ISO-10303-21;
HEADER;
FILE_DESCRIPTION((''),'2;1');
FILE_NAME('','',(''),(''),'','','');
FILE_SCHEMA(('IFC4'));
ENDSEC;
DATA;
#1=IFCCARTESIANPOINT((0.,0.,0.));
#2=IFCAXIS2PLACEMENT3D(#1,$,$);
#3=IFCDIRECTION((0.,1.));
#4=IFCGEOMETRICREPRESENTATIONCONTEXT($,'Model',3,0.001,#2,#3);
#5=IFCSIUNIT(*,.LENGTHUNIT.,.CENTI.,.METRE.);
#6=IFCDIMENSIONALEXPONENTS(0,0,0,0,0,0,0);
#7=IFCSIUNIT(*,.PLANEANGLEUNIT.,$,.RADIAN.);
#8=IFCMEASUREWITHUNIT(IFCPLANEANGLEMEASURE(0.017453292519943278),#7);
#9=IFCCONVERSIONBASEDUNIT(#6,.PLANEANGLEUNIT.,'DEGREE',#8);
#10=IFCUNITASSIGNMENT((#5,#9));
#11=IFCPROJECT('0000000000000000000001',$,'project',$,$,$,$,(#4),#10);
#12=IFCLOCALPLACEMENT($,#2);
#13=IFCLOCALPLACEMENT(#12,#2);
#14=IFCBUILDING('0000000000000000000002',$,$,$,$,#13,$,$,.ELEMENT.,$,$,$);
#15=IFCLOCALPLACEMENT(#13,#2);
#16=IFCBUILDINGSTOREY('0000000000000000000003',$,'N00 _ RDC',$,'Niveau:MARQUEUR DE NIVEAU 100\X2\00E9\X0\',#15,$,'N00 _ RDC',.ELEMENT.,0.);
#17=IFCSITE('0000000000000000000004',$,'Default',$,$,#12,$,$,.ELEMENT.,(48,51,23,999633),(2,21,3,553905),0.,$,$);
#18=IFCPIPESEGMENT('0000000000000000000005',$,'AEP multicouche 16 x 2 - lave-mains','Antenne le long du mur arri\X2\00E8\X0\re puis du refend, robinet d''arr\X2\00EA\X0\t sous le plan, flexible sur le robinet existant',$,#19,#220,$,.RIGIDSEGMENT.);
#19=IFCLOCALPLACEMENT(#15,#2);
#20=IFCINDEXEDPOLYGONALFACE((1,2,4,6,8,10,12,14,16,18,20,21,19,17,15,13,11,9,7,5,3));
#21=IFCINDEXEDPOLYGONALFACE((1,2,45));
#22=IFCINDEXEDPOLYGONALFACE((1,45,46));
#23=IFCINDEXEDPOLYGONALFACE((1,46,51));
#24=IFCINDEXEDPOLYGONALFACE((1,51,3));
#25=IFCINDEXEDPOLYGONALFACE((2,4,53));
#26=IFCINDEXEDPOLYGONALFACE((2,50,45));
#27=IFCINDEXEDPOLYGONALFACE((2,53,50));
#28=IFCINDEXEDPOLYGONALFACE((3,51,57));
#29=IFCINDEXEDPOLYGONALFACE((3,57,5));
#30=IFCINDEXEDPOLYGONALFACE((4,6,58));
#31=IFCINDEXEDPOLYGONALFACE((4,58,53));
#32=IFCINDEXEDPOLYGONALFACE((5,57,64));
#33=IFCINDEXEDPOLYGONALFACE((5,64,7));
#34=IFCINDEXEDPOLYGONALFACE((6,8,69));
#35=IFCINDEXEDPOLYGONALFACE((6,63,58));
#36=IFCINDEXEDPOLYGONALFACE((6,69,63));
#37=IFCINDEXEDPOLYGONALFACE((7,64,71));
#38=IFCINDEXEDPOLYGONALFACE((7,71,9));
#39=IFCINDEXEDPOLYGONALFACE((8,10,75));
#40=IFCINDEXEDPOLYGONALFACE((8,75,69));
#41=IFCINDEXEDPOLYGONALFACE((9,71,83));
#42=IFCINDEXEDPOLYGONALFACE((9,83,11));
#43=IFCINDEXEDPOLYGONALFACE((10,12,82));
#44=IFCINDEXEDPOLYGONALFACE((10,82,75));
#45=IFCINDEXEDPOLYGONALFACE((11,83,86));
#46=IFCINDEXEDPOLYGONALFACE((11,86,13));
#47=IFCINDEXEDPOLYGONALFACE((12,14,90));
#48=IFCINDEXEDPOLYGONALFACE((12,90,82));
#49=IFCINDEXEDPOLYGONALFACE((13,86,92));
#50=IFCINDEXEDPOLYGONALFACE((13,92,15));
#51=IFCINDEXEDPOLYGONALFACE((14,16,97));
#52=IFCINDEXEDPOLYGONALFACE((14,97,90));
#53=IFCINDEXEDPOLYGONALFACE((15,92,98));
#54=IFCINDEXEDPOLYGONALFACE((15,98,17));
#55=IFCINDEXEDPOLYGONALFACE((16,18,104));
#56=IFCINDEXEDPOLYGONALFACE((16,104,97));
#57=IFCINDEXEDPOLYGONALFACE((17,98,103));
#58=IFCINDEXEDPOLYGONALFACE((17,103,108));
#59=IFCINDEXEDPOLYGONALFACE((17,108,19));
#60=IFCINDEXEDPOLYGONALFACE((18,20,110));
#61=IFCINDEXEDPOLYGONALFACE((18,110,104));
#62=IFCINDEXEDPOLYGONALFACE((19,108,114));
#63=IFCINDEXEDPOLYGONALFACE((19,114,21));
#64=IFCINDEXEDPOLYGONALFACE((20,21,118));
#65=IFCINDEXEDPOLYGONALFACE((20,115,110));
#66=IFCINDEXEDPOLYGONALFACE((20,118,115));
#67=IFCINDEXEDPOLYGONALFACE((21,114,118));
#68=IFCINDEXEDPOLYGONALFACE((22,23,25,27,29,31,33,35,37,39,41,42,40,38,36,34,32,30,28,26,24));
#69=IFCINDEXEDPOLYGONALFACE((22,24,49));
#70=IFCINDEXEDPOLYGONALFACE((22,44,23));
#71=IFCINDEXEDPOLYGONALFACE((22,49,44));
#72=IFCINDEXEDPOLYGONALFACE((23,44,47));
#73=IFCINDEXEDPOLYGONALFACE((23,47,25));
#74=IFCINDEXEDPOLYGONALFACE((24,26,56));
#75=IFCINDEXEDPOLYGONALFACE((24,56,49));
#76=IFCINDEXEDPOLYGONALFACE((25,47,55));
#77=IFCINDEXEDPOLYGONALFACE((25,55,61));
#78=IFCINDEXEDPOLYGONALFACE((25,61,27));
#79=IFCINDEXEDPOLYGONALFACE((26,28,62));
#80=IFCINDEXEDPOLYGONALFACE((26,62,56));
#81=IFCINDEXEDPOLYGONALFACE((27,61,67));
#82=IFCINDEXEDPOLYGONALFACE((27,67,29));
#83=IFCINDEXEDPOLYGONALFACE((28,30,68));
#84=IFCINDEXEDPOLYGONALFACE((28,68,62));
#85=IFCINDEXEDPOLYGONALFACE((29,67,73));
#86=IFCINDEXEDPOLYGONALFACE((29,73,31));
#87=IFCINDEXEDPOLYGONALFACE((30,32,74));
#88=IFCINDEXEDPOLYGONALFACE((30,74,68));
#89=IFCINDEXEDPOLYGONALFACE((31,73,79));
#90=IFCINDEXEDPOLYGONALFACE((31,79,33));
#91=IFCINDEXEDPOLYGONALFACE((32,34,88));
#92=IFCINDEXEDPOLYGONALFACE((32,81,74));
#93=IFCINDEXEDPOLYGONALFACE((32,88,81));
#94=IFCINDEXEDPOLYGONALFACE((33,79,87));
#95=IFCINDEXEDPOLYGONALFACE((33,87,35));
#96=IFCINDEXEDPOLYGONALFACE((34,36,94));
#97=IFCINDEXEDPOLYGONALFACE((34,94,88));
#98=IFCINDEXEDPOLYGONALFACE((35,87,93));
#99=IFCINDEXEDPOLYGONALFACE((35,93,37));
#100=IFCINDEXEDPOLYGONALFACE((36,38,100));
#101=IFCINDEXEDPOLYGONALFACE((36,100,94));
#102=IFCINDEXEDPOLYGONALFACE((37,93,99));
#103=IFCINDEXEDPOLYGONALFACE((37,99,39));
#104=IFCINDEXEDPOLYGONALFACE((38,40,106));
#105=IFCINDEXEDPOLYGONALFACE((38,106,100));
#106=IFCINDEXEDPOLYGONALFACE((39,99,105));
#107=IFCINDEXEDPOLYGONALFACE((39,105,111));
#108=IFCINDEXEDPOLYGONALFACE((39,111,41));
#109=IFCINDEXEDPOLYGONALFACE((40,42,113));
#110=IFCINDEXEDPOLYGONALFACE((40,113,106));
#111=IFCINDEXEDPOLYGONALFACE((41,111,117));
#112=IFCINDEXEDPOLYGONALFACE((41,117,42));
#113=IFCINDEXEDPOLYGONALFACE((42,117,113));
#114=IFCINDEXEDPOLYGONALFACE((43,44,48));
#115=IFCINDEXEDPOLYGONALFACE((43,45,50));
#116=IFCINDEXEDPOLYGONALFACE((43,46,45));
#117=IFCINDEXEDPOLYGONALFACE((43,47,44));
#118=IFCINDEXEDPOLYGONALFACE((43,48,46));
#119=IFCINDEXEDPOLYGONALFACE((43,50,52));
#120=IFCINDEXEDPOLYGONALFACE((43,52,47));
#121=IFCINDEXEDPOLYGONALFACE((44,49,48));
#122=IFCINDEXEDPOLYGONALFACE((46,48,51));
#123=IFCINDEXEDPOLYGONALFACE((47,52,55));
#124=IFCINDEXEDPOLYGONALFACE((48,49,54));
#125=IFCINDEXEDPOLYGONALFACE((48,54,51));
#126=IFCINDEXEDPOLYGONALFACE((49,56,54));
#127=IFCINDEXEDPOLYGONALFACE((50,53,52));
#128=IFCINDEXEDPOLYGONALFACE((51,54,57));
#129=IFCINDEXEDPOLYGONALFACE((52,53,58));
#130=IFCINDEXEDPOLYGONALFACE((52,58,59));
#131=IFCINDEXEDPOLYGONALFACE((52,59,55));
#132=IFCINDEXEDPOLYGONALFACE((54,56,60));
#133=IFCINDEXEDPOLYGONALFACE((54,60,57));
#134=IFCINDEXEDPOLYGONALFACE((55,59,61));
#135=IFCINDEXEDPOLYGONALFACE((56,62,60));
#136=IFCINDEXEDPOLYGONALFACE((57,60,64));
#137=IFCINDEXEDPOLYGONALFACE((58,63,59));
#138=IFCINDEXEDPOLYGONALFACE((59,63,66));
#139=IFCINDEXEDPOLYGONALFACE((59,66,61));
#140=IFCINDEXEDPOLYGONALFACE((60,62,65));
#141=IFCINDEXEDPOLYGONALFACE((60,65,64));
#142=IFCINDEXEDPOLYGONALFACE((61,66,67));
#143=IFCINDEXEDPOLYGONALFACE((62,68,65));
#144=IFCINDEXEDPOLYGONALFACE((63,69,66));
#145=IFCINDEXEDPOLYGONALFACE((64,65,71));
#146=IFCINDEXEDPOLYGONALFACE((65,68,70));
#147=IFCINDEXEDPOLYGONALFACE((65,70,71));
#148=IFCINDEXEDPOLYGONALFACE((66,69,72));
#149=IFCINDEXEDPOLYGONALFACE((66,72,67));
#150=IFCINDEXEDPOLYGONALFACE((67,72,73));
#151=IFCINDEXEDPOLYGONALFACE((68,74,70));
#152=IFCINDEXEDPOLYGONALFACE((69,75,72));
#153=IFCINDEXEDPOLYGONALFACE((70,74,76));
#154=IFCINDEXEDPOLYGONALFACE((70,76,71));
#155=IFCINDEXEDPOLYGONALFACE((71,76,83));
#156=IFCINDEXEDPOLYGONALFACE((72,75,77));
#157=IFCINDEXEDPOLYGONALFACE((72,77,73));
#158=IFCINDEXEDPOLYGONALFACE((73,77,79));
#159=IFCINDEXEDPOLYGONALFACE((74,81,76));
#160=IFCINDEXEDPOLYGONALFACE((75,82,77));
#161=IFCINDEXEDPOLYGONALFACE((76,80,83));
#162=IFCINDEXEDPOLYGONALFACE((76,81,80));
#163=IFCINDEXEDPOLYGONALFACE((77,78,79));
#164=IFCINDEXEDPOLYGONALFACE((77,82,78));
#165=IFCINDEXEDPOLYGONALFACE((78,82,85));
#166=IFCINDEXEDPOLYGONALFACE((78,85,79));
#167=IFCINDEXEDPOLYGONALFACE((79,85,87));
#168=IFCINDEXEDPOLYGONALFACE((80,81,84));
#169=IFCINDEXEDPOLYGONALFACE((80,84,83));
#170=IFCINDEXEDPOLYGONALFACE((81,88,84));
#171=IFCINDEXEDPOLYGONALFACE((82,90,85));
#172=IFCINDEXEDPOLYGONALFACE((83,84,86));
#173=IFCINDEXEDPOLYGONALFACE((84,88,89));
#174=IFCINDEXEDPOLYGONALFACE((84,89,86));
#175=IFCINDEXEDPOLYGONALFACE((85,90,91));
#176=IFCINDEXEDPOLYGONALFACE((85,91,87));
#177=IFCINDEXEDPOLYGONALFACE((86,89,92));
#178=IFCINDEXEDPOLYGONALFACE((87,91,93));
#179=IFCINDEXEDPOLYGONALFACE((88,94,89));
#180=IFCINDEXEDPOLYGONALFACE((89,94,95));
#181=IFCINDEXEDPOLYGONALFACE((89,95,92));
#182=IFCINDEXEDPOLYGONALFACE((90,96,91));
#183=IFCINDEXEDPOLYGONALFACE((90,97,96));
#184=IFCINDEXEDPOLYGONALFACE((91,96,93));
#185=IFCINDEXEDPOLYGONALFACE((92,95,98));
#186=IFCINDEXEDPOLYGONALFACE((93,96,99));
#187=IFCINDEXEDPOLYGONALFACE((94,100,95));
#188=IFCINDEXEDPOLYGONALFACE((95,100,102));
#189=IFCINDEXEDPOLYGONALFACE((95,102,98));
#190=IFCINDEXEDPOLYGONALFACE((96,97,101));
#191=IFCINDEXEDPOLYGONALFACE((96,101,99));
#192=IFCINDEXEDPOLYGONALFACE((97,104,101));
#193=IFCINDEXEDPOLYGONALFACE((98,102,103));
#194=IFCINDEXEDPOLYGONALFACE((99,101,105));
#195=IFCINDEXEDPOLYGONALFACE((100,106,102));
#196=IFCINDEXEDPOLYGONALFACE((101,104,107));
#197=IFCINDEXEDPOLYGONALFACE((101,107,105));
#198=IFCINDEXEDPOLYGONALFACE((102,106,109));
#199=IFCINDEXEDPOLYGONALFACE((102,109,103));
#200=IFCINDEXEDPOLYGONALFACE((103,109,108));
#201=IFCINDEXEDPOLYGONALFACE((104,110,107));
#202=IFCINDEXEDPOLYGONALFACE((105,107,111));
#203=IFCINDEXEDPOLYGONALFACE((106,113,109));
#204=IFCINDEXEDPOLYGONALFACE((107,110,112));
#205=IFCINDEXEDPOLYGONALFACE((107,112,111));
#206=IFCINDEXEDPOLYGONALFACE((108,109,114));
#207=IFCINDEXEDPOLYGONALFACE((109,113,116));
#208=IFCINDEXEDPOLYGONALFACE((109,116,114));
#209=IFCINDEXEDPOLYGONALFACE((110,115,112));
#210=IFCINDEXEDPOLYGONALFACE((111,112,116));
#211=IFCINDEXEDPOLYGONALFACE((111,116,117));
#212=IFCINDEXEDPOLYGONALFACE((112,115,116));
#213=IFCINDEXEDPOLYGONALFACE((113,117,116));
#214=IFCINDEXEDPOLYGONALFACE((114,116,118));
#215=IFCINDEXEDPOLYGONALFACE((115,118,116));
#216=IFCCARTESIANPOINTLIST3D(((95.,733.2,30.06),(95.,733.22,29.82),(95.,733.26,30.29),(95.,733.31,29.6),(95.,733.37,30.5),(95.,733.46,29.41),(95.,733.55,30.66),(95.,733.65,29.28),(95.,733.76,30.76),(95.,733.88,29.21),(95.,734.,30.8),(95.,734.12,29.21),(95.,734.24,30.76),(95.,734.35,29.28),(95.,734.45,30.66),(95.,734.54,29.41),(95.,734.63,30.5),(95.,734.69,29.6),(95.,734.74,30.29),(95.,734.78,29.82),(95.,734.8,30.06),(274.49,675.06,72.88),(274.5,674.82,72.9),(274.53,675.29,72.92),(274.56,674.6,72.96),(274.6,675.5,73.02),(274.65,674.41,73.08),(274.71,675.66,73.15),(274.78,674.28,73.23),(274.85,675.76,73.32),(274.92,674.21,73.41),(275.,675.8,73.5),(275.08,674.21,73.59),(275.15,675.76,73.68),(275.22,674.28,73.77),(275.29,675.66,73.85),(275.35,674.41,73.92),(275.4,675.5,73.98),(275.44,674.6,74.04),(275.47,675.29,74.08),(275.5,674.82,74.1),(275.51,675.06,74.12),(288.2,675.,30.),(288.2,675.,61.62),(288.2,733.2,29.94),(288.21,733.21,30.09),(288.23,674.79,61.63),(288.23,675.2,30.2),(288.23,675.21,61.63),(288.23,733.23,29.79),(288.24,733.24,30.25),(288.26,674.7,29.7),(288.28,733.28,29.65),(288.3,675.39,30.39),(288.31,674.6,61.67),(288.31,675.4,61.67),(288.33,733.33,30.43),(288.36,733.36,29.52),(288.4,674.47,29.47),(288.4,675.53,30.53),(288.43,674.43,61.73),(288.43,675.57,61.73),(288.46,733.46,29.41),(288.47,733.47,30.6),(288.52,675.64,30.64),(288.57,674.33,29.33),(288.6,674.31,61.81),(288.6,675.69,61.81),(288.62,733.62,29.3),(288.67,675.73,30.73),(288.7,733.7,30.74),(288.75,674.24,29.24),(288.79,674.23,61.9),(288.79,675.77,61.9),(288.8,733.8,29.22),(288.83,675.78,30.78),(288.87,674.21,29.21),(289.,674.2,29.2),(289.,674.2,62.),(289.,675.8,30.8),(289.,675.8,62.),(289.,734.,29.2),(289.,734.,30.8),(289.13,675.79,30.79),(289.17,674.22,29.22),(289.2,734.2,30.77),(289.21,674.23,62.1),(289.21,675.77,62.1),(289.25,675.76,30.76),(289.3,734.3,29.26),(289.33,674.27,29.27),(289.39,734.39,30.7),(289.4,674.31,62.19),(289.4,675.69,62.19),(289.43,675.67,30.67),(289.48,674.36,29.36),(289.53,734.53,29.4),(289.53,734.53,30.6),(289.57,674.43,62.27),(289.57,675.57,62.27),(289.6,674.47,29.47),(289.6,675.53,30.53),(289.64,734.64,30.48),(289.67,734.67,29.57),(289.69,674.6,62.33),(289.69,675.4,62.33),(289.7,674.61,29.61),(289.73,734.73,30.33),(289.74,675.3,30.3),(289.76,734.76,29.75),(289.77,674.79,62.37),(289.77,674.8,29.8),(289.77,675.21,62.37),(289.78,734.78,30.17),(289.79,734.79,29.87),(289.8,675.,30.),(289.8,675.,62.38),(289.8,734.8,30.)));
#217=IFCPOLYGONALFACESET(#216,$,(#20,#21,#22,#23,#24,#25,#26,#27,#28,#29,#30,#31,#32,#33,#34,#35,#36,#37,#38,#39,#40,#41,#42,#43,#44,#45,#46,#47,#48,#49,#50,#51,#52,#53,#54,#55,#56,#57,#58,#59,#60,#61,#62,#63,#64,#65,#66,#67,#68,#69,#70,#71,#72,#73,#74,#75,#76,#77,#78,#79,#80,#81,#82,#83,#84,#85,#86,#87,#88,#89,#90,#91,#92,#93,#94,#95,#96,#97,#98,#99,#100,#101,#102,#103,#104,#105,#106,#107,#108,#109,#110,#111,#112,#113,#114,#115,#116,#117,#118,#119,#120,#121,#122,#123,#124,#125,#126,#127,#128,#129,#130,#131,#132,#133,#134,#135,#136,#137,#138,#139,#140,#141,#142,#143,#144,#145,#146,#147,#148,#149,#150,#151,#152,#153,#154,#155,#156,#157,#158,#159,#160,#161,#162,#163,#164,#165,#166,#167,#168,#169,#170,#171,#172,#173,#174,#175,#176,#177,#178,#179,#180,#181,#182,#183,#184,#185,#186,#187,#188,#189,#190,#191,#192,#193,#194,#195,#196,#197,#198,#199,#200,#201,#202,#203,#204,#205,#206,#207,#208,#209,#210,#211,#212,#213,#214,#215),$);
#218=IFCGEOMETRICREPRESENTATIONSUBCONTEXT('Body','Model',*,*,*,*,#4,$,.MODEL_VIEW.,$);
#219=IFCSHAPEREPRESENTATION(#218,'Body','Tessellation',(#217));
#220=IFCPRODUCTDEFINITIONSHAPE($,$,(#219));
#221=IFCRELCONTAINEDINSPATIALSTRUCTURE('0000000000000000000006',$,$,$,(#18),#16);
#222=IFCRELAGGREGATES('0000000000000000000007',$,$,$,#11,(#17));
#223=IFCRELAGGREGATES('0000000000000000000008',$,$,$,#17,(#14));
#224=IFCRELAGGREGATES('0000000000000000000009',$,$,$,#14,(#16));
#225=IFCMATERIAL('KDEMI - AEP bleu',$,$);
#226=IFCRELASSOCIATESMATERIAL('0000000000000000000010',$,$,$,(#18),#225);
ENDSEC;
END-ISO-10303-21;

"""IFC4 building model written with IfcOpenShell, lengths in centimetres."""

from ifc_helpers import new_model, entity, si_unit, converted_unit, direction, origin, origin_with_axes, place, context, subcontext, project, spatial, material, element, save


model = new_model("IFC4")

# Units and contexts
model_context = context("Model", 3, precision=0.001, world=origin(), true_north=direction((0.0, 1.0)))
body_context = subcontext(model_context, "Body", "Model", "MODEL_VIEW")
ifc_project = project(units=[si_unit("LENGTHUNIT", "METRE", prefix="CENTI"), converted_unit("PLANEANGLEUNIT", "DEGREE", entity("IfcPlaneAngleMeasure", 0.017453292519943278), si_unit("PLANEANGLEUNIT", "RADIAN"), dimensions=[0, 0, 0, 0, 0, 0, 0])], contexts=[model_context])

# Site, building, storey
site_placement = place(None, origin())
site = spatial("IfcSite", under=ifc_project, at=site_placement, Name="Default", CompositionType="ELEMENT", RefLatitude=(48, 51, 23, 999633), RefLongitude=(2, 21, 3, 553905), RefElevation=0.0)
building_placement = place(site_placement, origin())
building = spatial("IfcBuilding", under=site, at=building_placement, CompositionType="ELEMENT")
storey_placement = place(building_placement, origin())
storey = spatial("IfcBuildingStorey", under=building, at=storey_placement, Name="N00 _ RDC", ObjectType="Niveau:MARQUEUR DE NIVEAU 100é", LongName="N00 _ RDC", CompositionType="ELEMENT", Elevation=0.0)

# Pipe segment
ifc_material_1 = material(Name="KDEMI - AEP bleu")
pipe_segment_1_placement = place(storey_placement, origin_with_axes())
element("IfcPipeSegment", 1, at=pipe_segment_1_placement, inside=storey, material=ifc_material_1, Name="AEP multicouche 16 x 2 - lave-mains", Description="Antenne le long du mur arrière puis du refend, robinet d'arrêt sous le plan, flexible sur le robinet existant", PredefinedType="RIGIDSEGMENT", context=body_context, shape_type="AdvancedSweptSolid", body=[
    entity("IfcSweptDiskSolid", entity("IfcPolyline", [entity("IfcCartesianPoint", [95.0, 734.0, 30.0]), entity("IfcCartesianPoint", [289.0, 734.0, 30.0]), entity("IfcCartesianPoint", [289.0, 675.0, 30.0]), entity("IfcCartesianPoint", [289.0, 675.0, 62.0]), entity("IfcCartesianPoint", [275.0, 675.0, 73.5])]), 0.8),
])

save(model, "model.ifc")
